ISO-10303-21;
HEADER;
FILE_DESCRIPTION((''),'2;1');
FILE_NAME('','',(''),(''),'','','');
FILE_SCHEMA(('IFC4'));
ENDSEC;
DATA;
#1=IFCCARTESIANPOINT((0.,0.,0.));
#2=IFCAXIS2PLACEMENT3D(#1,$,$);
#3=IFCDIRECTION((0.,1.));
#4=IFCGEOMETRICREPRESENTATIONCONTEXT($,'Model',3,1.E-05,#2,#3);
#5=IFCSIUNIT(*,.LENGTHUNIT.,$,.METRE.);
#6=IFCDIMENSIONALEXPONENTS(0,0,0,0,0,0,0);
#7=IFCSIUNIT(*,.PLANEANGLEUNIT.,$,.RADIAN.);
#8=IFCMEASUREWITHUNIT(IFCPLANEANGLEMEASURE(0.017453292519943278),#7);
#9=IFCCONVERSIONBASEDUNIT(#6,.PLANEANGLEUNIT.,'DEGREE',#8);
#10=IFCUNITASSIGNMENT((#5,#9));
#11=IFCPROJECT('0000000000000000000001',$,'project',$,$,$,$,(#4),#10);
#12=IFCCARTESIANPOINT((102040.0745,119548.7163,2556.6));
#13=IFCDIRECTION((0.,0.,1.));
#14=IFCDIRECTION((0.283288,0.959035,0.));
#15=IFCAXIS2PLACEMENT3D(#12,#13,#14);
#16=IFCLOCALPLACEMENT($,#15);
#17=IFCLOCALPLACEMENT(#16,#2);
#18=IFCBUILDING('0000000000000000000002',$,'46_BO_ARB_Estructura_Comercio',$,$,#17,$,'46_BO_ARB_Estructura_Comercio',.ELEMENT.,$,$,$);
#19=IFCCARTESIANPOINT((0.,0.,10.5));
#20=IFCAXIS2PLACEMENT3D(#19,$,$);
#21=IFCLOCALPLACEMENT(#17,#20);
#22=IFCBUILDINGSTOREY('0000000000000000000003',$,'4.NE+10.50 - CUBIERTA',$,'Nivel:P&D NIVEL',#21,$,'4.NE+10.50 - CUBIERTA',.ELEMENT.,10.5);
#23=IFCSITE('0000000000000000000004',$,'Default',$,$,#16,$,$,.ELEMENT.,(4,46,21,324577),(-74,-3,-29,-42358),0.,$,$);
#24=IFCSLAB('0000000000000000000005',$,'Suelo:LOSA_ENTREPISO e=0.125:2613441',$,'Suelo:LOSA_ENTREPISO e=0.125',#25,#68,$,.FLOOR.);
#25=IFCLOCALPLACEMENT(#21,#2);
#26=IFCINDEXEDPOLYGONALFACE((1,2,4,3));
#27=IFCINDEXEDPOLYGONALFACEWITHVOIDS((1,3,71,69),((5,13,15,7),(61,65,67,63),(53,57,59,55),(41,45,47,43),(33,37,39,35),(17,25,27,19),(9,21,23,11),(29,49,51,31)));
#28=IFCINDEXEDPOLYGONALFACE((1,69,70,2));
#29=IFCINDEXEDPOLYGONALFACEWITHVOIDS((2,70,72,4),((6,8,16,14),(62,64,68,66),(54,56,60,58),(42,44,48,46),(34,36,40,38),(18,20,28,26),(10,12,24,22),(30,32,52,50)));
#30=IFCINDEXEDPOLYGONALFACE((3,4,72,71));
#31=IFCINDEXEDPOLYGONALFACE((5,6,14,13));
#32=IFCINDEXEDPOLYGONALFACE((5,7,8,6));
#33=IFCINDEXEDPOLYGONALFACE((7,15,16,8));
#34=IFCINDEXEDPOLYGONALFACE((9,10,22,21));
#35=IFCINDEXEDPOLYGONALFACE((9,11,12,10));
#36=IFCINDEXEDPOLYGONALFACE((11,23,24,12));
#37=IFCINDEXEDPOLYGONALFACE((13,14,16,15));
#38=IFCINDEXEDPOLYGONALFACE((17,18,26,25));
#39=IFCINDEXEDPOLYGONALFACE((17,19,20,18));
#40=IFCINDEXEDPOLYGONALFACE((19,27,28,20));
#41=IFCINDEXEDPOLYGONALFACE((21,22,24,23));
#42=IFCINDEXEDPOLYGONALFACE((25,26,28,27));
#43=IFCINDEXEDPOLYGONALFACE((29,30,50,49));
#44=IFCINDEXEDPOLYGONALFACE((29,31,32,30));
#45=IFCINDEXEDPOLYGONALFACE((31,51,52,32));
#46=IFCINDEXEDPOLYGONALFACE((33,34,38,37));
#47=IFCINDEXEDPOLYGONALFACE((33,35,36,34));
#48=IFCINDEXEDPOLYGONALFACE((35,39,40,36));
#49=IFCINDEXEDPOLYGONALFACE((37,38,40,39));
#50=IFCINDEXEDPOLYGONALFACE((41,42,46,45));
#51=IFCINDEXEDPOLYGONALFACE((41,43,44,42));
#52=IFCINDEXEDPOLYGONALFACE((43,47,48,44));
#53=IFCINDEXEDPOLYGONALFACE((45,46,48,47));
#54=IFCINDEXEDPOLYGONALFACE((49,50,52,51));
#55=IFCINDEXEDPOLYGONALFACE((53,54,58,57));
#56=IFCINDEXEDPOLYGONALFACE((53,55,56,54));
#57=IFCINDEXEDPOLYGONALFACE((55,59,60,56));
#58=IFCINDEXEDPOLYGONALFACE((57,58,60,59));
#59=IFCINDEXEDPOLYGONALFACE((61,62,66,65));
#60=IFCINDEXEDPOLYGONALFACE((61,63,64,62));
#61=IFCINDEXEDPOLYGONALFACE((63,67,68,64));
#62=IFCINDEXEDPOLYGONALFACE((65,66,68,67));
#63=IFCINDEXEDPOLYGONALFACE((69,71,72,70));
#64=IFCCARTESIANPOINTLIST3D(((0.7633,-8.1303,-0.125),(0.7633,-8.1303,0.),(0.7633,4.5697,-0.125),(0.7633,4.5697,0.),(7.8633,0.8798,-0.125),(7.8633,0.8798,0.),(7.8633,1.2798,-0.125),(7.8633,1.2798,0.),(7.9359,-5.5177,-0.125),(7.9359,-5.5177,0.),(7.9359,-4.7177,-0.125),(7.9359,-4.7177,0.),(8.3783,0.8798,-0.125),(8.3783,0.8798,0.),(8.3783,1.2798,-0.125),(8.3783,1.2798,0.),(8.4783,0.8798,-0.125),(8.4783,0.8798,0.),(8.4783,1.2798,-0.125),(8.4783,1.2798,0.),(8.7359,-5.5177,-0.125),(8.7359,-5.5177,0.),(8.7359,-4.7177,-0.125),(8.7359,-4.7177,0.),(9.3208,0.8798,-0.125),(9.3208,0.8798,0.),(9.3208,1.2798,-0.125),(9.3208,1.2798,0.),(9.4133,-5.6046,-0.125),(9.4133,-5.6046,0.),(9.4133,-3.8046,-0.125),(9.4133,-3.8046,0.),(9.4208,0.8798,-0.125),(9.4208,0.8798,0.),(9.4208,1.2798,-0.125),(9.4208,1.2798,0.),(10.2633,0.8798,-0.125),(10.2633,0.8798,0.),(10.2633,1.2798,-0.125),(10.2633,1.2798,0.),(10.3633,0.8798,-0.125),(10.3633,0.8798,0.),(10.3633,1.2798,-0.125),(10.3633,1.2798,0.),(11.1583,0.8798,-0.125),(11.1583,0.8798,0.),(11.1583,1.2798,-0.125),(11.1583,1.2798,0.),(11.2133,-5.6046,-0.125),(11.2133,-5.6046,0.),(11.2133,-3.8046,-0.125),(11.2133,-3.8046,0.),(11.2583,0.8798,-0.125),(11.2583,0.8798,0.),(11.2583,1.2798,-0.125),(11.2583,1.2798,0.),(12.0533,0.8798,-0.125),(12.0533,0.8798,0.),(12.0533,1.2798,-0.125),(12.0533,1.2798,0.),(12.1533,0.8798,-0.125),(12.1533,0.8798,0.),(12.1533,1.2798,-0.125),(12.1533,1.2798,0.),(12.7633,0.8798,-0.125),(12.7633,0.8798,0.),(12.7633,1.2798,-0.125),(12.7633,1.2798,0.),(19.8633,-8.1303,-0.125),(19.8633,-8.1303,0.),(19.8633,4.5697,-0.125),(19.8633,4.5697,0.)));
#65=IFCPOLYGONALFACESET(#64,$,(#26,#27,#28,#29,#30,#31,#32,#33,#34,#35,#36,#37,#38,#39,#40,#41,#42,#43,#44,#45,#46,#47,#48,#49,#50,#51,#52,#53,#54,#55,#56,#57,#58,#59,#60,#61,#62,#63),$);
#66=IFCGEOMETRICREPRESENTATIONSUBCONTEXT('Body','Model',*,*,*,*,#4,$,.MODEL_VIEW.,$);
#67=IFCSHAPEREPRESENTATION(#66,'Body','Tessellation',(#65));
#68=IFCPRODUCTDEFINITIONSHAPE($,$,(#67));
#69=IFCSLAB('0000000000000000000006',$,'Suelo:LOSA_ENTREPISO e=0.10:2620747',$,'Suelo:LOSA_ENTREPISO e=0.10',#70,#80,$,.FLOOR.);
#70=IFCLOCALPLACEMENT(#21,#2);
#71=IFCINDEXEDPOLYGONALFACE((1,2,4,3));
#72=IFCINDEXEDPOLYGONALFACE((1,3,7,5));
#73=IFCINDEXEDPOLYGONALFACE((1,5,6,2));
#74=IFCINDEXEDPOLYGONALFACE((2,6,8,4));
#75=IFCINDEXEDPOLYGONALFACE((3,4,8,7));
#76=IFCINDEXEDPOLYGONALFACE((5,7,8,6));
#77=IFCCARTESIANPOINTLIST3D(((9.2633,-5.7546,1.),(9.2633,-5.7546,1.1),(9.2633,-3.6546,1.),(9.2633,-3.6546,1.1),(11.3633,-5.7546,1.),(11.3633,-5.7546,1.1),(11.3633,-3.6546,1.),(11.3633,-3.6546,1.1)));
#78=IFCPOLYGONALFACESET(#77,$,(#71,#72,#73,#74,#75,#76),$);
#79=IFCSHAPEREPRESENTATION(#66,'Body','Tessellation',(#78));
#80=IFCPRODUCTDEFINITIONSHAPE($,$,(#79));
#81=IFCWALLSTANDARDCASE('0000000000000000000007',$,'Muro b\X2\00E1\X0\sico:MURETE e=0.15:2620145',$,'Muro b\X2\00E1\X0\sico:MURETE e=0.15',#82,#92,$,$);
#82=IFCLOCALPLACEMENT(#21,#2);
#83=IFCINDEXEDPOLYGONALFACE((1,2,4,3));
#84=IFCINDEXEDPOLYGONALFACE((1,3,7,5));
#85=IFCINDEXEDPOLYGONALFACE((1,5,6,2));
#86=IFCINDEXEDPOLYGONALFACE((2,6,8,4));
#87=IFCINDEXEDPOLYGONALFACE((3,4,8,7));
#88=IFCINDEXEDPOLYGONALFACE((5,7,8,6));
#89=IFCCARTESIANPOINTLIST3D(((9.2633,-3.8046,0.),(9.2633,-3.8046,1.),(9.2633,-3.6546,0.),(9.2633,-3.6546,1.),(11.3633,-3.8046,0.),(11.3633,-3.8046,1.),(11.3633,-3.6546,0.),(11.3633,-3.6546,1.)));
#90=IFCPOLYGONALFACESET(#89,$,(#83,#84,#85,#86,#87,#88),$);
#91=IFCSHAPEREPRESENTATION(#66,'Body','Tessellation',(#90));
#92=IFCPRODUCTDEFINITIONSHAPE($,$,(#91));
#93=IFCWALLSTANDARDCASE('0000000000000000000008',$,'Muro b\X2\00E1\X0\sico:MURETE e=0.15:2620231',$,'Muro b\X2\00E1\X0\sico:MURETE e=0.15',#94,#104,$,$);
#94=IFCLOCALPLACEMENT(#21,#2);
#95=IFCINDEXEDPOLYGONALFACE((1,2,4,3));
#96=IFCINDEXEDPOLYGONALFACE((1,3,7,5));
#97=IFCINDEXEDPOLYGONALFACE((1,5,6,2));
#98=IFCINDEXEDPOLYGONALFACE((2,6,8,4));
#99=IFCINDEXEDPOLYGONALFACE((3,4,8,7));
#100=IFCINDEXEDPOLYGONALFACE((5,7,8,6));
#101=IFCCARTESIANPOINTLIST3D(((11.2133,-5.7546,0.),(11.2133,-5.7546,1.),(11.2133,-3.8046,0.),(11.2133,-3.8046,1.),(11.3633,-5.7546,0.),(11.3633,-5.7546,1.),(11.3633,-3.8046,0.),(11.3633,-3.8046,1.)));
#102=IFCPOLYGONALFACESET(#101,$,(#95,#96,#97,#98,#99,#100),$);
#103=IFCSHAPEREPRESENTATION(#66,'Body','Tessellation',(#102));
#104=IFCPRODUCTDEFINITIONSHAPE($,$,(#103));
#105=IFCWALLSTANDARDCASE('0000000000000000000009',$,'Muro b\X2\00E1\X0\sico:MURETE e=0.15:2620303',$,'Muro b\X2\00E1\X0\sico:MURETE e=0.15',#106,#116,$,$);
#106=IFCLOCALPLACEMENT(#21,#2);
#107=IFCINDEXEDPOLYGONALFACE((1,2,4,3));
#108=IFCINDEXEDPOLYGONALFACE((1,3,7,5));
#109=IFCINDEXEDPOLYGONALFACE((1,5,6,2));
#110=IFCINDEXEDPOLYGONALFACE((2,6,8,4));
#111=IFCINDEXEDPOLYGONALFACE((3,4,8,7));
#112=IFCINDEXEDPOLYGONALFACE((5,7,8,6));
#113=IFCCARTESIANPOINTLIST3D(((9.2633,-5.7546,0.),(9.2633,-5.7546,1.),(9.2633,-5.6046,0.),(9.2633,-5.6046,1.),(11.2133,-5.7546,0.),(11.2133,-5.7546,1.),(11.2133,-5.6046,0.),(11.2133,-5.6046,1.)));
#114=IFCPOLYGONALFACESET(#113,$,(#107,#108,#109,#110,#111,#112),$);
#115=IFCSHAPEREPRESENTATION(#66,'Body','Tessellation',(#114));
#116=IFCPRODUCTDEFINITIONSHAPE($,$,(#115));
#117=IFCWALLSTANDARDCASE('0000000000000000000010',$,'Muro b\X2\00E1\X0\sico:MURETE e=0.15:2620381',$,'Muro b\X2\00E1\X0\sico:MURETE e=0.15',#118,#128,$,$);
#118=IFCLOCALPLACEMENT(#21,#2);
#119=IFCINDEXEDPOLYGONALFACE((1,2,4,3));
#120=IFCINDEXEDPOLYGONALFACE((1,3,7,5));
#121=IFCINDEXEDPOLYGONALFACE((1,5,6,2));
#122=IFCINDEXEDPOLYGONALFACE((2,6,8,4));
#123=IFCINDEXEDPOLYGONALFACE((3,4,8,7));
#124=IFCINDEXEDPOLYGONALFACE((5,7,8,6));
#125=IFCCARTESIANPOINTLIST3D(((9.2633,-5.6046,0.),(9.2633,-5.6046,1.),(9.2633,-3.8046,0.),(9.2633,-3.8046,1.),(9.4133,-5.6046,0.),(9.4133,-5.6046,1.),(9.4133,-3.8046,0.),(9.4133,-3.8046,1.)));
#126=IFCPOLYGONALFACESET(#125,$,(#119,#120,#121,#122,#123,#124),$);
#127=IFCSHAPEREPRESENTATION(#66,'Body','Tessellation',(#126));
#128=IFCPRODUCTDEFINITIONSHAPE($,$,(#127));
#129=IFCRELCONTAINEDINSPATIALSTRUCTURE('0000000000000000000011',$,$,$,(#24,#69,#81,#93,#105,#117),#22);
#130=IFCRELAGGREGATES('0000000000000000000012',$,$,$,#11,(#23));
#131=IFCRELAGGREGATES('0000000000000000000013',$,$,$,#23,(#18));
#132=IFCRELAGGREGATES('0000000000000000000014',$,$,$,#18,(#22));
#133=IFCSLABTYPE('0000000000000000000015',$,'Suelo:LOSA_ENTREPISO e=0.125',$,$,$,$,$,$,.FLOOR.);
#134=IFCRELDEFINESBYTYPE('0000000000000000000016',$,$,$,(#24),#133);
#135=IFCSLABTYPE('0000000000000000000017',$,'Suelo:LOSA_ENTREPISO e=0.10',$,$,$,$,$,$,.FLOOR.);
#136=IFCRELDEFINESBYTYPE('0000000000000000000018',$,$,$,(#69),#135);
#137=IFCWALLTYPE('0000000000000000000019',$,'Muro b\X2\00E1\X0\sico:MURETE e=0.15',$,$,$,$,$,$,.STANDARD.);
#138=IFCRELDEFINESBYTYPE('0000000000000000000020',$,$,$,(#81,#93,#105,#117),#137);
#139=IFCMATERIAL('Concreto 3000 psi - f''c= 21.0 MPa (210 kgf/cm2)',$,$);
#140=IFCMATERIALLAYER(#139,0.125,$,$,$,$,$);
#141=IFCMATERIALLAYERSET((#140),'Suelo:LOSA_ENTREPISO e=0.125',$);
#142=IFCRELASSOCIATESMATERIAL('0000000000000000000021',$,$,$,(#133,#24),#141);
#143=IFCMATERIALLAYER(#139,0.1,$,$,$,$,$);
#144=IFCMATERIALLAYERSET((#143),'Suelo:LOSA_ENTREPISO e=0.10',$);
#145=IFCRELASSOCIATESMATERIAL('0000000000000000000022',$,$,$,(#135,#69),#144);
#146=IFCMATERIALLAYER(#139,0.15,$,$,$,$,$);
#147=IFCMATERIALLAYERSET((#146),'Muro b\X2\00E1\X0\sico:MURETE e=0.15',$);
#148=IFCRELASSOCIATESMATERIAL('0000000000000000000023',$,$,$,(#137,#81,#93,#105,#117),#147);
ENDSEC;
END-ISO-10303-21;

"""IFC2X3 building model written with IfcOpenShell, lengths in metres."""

from ifc_helpers import new_model, entity, si_unit, converted_unit, direction, frame, frame_2d, origin, origin_2d_with_axis, place, context, subcontext, project, spatial, rectangle, extrude, boolean, material, layer, layer_set, layer_usage, type_object, element, save


model = new_model("IFC2X3")

# Units and contexts
model_context = context("Model", 3, precision=1e-05, world=origin(), true_north=direction((0.0, 1.0)))
body_context = subcontext(model_context, "Body", "Model", "MODEL_VIEW")
ifc_project = project(units=[si_unit("LENGTHUNIT", "METRE"), converted_unit("PLANEANGLEUNIT", "DEGREE", entity("IfcPlaneAngleMeasure", 0.017453292519943278), si_unit("PLANEANGLEUNIT", "RADIAN"), dimensions=[0, 0, 0, 0, 0, 0, 0])], contexts=[model_context])

# Site, building, storey
site_placement = place(None, frame((102040.0745, 119548.7163, 2556.6), z_axis=(0.0, 0.0, 1.0), x_axis=(0.283288, 0.959035, 0.0)))
site = spatial("IfcSite", under=ifc_project, at=site_placement, Name="Default", CompositionType="ELEMENT", RefLatitude=(4, 46, 21, 324577), RefLongitude=(-74, -3, -29, -42358), RefElevation=0.0)
building_placement = place(site_placement, origin())
building = spatial("IfcBuilding", under=site, at=building_placement, Name="46_BO_ARB_Estructura_Comercio", LongName="46_BO_ARB_Estructura_Comercio", CompositionType="ELEMENT")
storey_placement = place(building_placement, frame((0.0, 0.0, 10.5)))
storey = spatial("IfcBuildingStorey", under=building, at=storey_placement, Name="4.NE+10.50 - CUBIERTA", ObjectType="Nivel:P&D NIVEL", LongName="4.NE+10.50 - CUBIERTA", CompositionType="ELEMENT", Elevation=10.5)

# Shared definitions
ifc_material = material(Name="Concreto 3000 psi - f'c= 21.0 MPa (210 kgf/cm2)")

# Slab, openings
ifc_layer_1 = layer(ifc_material, 0.125)
ifc_layer_set_1 = layer_set([ifc_layer_1], Name="Suelo:LOSA_ENTREPISO e=0.125")
ifc_layer_usage_1 = layer_usage(ifc_layer_set_1, "AXIS3", "POSITIVE", 0.0)
slab_type_1 = type_object("IfcSlabType", Name="Suelo:LOSA_ENTREPISO e=0.125", PredefinedType="FLOOR", material=ifc_layer_set_1)
slab_1_placement = place(storey_placement, origin())
slab_1 = element("IfcSlab", 1, at=slab_1_placement, inside=storey, type_object=slab_type_1, material=ifc_layer_usage_1, Name="Suelo:LOSA_ENTREPISO e=0.125:2613441", ObjectType="Suelo:LOSA_ENTREPISO e=0.125", PredefinedType="FLOOR", context=body_context, shape_type="SweptSolid", body=[
    boolean("DIFFERENCE", boolean("DIFFERENCE", boolean("DIFFERENCE", boolean("DIFFERENCE", boolean("DIFFERENCE", boolean("DIFFERENCE", boolean("DIFFERENCE", boolean("DIFFERENCE", extrude(rectangle(XDim=12.7, YDim=19.1, at=origin_2d_with_axis()), frame((10.3133, -1.7803, 0.0), z_axis=(0.0, 0.0, -1.0), x_axis=(0.0, 1.0, 0.0)), (0.0, 0.0, 1.0), 0.125), extrude(rectangle(XDim=0.8, YDim=0.8, at=origin_2d_with_axis()), frame((8.3359, -5.1177, -0.125), z_axis=(0.0, 0.0, 1.0), x_axis=(0.0, 1.0, 0.0)), (0.0, 0.0, 1.0), 0.125)), extrude(rectangle(XDim=0.4, YDim=0.8425, at=origin_2d_with_axis()), frame((8.8995, 1.0798, -0.125), z_axis=(0.0, 0.0, 1.0), x_axis=(0.0, 1.0, 0.0)), (0.0, 0.0, 1.0), 0.125)), extrude(rectangle(XDim=0.4, YDim=0.8425, at=origin_2d_with_axis()), frame((9.842, 1.0798, -0.125), z_axis=(0.0, 0.0, 1.0), x_axis=(0.0, 1.0, 0.0)), (0.0, 0.0, 1.0), 0.125)), extrude(rectangle(XDim=0.4, YDim=0.795, at=frame_2d((0.0, 0.0), x_axis=(1.0, 0.0))), frame((10.7608, 1.0798, -0.125), z_axis=(0.0, 0.0, 1.0), x_axis=(0.0, 1.0, 0.0)), (0.0, 0.0, 1.0), 0.125)), extrude(rectangle(XDim=1.8, YDim=1.8, at=origin_2d_with_axis()), frame((10.3133, -4.7046, -0.125), z_axis=(0.0, 0.0, 1.0), x_axis=(0.0, 1.0, 0.0)), (0.0, 0.0, 1.0), 0.125)), extrude(rectangle(XDim=0.4, YDim=0.795, at=frame_2d((0.0, 0.0), x_axis=(1.0, 0.0))), frame((11.6558, 1.0798, -0.125), z_axis=(0.0, 0.0, 1.0), x_axis=(0.0, 1.0, 0.0)), (0.0, 0.0, 1.0), 0.125)), extrude(rectangle(XDim=0.4, YDim=0.61, at=frame_2d((0.0, 0.0), x_axis=(1.0, 0.0))), frame((12.4583, 1.0798, -0.125), z_axis=(0.0, 0.0, 1.0), x_axis=(0.0, 1.0, 0.0)), (0.0, 0.0, 1.0), 0.125)), extrude(rectangle(XDim=0.4, YDim=0.515, at=origin_2d_with_axis()), frame((8.1208, 1.0798, -0.125), z_axis=(0.0, 0.0, 1.0), x_axis=(0.0, 1.0, 0.0)), (0.0, 0.0, 1.0), 0.125)),
])
opening_1_placement = place(slab_1_placement, origin())
element("IfcOpeningElement", 2, at=opening_1_placement, cuts=slab_1, ObjectType="Opening", context=body_context, shape_type="SweptSolid", body=[
    extrude(rectangle(XDim=0.515, YDim=0.4, at=origin_2d_with_axis()), frame((8.1208, 1.0798, 0.0), z_axis=(0.0, 0.0, -1.0), x_axis=(-1.0, 0.0, 0.0)), (0.0, 0.0, 1.0), 0.125),
])
opening_2_placement = place(slab_1_placement, origin())
element("IfcOpeningElement", 3, at=opening_2_placement, cuts=slab_1, ObjectType="Opening", context=body_context, shape_type="SweptSolid", body=[
    extrude(rectangle(XDim=0.4, YDim=0.8425, at=frame_2d((0.0, 0.0), x_axis=(1.0, 0.0))), frame((8.8995, 1.0798, 0.0), z_axis=(0.0, 0.0, -1.0), x_axis=(0.0, -1.0, 0.0)), (0.0, 0.0, 1.0), 0.125),
])
opening_3_placement = place(slab_1_placement, origin())
element("IfcOpeningElement", 4, at=opening_3_placement, cuts=slab_1, ObjectType="Opening", context=body_context, shape_type="SweptSolid", body=[
    extrude(rectangle(XDim=0.4, YDim=0.8425, at=origin_2d_with_axis()), frame((9.842, 1.0798, 0.0), z_axis=(0.0, 0.0, -1.0), x_axis=(0.0, -1.0, 0.0)), (0.0, 0.0, 1.0), 0.125),
])
opening_4_placement = place(slab_1_placement, origin())
element("IfcOpeningElement", 5, at=opening_4_placement, cuts=slab_1, ObjectType="Opening", context=body_context, shape_type="SweptSolid", body=[
    extrude(rectangle(XDim=0.4, YDim=0.795, at=frame_2d((0.0, 0.0), x_axis=(1.0, 0.0))), frame((10.7608, 1.0798, 0.0), z_axis=(0.0, 0.0, -1.0), x_axis=(0.0, -1.0, 0.0)), (0.0, 0.0, 1.0), 0.125),
])
opening_5_placement = place(slab_1_placement, origin())
element("IfcOpeningElement", 6, at=opening_5_placement, cuts=slab_1, ObjectType="Opening", context=body_context, shape_type="SweptSolid", body=[
    extrude(rectangle(XDim=0.4, YDim=0.795, at=frame_2d((0.0, 0.0), x_axis=(1.0, 0.0))), frame((11.6558, 1.0798, 0.0), z_axis=(0.0, 0.0, -1.0), x_axis=(0.0, -1.0, 0.0)), (0.0, 0.0, 1.0), 0.125),
])
opening_6_placement = place(slab_1_placement, origin())
element("IfcOpeningElement", 7, at=opening_6_placement, cuts=slab_1, ObjectType="Opening", context=body_context, shape_type="SweptSolid", body=[
    extrude(rectangle(XDim=0.4, YDim=0.61, at=frame_2d((0.0, 0.0), x_axis=(1.0, 0.0))), frame((12.4583, 1.0798, 0.0), z_axis=(0.0, 0.0, -1.0), x_axis=(0.0, -1.0, 0.0)), (0.0, 0.0, 1.0), 0.125),
])
opening_7_placement = place(slab_1_placement, origin())
element("IfcOpeningElement", 8, at=opening_7_placement, cuts=slab_1, ObjectType="Opening", context=body_context, shape_type="SweptSolid", body=[
    extrude(rectangle(XDim=1.8, YDim=1.8, at=frame_2d((0.0, 0.0), x_axis=(1.0, 0.0))), frame((10.3133, -4.7046, 0.0), z_axis=(0.0, 0.0, -1.0), x_axis=(0.0, -1.0, 0.0)), (0.0, 0.0, 1.0), 0.125),
])
opening_8_placement = place(slab_1_placement, origin())
element("IfcOpeningElement", 9, at=opening_8_placement, cuts=slab_1, ObjectType="Opening", context=body_context, shape_type="SweptSolid", body=[
    extrude(rectangle(XDim=0.8, YDim=0.8, at=origin_2d_with_axis()), frame((8.3359, -5.1177, 0.0), z_axis=(0.0, 0.0, -1.0), x_axis=(0.0, -1.0, 0.0)), (0.0, 0.0, 1.0), 0.125),
])

# Slab
ifc_layer_2 = layer(ifc_material, 0.1)
ifc_layer_set_2 = layer_set([ifc_layer_2], Name="Suelo:LOSA_ENTREPISO e=0.10")
ifc_layer_usage_2 = layer_usage(ifc_layer_set_2, "AXIS3", "POSITIVE", 0.0)
slab_type_2 = type_object("IfcSlabType", Name="Suelo:LOSA_ENTREPISO e=0.10", PredefinedType="FLOOR", material=ifc_layer_set_2)
slab_2_placement = place(storey_placement, origin())
element("IfcSlab", 10, at=slab_2_placement, inside=storey, type_object=slab_type_2, material=ifc_layer_usage_2, Name="Suelo:LOSA_ENTREPISO e=0.10:2620747", ObjectType="Suelo:LOSA_ENTREPISO e=0.10", PredefinedType="FLOOR", context=body_context, shape_type="SweptSolid", body=[
    extrude(rectangle(XDim=2.1, YDim=2.1, at=frame_2d((0.0, 0.0), x_axis=(1.0, 0.0))), frame((10.3133, -4.7046, 1.1), z_axis=(0.0, 0.0, -1.0), x_axis=(0.0, 1.0, 0.0)), (0.0, 0.0, 1.0), 0.1),
])

# Walls
ifc_layer_3 = layer(ifc_material, 0.15)
ifc_layer_set_3 = layer_set([ifc_layer_3], Name="Muro básico:MURETE e=0.15")
ifc_layer_usage_3 = layer_usage(ifc_layer_set_3, "AXIS2", "NEGATIVE", 0.075)
wall_type = type_object("IfcWallType", Name="Muro básico:MURETE e=0.15", PredefinedType="STANDARD", material=ifc_layer_set_3)
wall_1_placement = place(storey_placement, frame((9.2633, -3.7296, 0.0)))
element("IfcWallStandardCase", 11, at=wall_1_placement, inside=storey, type_object=wall_type, material=ifc_layer_usage_3, Name="Muro básico:MURETE e=0.15:2620145", ObjectType="Muro básico:MURETE e=0.15", context=body_context, shape_type="SweptSolid", body=[
    extrude(rectangle(XDim=2.1, YDim=0.15, at=frame_2d((1.05, 0.0), x_axis=(-1.0, 0.0))), origin(), (0.0, 0.0, 1.0), 1.0),
])
ifc_layer_usage_4 = layer_usage(ifc_layer_set_3, "AXIS2", "NEGATIVE", 0.075)
wall_2_placement = place(storey_placement, frame((11.2883, -3.8046, 0.0), z_axis=(0.0, 0.0, 1.0), x_axis=(0.0, -1.0, 0.0)))
element("IfcWallStandardCase", 12, at=wall_2_placement, inside=storey, type_object=wall_type, material=ifc_layer_usage_4, Name="Muro básico:MURETE e=0.15:2620231", ObjectType="Muro básico:MURETE e=0.15", context=body_context, shape_type="SweptSolid", body=[
    extrude(rectangle(XDim=1.95, YDim=0.15, at=frame_2d((0.975, 0.0), x_axis=(-1.0, 0.0))), origin(), (0.0, 0.0, 1.0), 1.0),
])
ifc_layer_usage_5 = layer_usage(ifc_layer_set_3, "AXIS2", "NEGATIVE", 0.075)
wall_3_placement = place(storey_placement, frame((11.2133, -5.6796, 0.0), z_axis=(0.0, 0.0, 1.0), x_axis=(-1.0, 0.0, 0.0)))
element("IfcWallStandardCase", 13, at=wall_3_placement, inside=storey, type_object=wall_type, material=ifc_layer_usage_5, Name="Muro básico:MURETE e=0.15:2620303", ObjectType="Muro básico:MURETE e=0.15", context=body_context, shape_type="SweptSolid", body=[
    extrude(rectangle(XDim=1.95, YDim=0.15, at=frame_2d((0.975, 0.0), x_axis=(-1.0, 0.0))), origin(), (0.0, 0.0, 1.0), 1.0),
])
ifc_layer_usage_6 = layer_usage(ifc_layer_set_3, "AXIS2", "NEGATIVE", 0.075)
wall_4_placement = place(storey_placement, frame((9.3383, -5.6046, 0.0), z_axis=(0.0, 0.0, 1.0), x_axis=(0.0, 1.0, 0.0)))
element("IfcWallStandardCase", 14, at=wall_4_placement, inside=storey, type_object=wall_type, material=ifc_layer_usage_6, Name="Muro básico:MURETE e=0.15:2620381", ObjectType="Muro básico:MURETE e=0.15", context=body_context, shape_type="SweptSolid", body=[
    extrude(rectangle(XDim=1.8, YDim=0.15, at=frame_2d((0.9, 0.0), x_axis=(-1.0, 0.0))), origin(), (0.0, 0.0, 1.0), 1.0),
])

save(model, "model.ifc")
